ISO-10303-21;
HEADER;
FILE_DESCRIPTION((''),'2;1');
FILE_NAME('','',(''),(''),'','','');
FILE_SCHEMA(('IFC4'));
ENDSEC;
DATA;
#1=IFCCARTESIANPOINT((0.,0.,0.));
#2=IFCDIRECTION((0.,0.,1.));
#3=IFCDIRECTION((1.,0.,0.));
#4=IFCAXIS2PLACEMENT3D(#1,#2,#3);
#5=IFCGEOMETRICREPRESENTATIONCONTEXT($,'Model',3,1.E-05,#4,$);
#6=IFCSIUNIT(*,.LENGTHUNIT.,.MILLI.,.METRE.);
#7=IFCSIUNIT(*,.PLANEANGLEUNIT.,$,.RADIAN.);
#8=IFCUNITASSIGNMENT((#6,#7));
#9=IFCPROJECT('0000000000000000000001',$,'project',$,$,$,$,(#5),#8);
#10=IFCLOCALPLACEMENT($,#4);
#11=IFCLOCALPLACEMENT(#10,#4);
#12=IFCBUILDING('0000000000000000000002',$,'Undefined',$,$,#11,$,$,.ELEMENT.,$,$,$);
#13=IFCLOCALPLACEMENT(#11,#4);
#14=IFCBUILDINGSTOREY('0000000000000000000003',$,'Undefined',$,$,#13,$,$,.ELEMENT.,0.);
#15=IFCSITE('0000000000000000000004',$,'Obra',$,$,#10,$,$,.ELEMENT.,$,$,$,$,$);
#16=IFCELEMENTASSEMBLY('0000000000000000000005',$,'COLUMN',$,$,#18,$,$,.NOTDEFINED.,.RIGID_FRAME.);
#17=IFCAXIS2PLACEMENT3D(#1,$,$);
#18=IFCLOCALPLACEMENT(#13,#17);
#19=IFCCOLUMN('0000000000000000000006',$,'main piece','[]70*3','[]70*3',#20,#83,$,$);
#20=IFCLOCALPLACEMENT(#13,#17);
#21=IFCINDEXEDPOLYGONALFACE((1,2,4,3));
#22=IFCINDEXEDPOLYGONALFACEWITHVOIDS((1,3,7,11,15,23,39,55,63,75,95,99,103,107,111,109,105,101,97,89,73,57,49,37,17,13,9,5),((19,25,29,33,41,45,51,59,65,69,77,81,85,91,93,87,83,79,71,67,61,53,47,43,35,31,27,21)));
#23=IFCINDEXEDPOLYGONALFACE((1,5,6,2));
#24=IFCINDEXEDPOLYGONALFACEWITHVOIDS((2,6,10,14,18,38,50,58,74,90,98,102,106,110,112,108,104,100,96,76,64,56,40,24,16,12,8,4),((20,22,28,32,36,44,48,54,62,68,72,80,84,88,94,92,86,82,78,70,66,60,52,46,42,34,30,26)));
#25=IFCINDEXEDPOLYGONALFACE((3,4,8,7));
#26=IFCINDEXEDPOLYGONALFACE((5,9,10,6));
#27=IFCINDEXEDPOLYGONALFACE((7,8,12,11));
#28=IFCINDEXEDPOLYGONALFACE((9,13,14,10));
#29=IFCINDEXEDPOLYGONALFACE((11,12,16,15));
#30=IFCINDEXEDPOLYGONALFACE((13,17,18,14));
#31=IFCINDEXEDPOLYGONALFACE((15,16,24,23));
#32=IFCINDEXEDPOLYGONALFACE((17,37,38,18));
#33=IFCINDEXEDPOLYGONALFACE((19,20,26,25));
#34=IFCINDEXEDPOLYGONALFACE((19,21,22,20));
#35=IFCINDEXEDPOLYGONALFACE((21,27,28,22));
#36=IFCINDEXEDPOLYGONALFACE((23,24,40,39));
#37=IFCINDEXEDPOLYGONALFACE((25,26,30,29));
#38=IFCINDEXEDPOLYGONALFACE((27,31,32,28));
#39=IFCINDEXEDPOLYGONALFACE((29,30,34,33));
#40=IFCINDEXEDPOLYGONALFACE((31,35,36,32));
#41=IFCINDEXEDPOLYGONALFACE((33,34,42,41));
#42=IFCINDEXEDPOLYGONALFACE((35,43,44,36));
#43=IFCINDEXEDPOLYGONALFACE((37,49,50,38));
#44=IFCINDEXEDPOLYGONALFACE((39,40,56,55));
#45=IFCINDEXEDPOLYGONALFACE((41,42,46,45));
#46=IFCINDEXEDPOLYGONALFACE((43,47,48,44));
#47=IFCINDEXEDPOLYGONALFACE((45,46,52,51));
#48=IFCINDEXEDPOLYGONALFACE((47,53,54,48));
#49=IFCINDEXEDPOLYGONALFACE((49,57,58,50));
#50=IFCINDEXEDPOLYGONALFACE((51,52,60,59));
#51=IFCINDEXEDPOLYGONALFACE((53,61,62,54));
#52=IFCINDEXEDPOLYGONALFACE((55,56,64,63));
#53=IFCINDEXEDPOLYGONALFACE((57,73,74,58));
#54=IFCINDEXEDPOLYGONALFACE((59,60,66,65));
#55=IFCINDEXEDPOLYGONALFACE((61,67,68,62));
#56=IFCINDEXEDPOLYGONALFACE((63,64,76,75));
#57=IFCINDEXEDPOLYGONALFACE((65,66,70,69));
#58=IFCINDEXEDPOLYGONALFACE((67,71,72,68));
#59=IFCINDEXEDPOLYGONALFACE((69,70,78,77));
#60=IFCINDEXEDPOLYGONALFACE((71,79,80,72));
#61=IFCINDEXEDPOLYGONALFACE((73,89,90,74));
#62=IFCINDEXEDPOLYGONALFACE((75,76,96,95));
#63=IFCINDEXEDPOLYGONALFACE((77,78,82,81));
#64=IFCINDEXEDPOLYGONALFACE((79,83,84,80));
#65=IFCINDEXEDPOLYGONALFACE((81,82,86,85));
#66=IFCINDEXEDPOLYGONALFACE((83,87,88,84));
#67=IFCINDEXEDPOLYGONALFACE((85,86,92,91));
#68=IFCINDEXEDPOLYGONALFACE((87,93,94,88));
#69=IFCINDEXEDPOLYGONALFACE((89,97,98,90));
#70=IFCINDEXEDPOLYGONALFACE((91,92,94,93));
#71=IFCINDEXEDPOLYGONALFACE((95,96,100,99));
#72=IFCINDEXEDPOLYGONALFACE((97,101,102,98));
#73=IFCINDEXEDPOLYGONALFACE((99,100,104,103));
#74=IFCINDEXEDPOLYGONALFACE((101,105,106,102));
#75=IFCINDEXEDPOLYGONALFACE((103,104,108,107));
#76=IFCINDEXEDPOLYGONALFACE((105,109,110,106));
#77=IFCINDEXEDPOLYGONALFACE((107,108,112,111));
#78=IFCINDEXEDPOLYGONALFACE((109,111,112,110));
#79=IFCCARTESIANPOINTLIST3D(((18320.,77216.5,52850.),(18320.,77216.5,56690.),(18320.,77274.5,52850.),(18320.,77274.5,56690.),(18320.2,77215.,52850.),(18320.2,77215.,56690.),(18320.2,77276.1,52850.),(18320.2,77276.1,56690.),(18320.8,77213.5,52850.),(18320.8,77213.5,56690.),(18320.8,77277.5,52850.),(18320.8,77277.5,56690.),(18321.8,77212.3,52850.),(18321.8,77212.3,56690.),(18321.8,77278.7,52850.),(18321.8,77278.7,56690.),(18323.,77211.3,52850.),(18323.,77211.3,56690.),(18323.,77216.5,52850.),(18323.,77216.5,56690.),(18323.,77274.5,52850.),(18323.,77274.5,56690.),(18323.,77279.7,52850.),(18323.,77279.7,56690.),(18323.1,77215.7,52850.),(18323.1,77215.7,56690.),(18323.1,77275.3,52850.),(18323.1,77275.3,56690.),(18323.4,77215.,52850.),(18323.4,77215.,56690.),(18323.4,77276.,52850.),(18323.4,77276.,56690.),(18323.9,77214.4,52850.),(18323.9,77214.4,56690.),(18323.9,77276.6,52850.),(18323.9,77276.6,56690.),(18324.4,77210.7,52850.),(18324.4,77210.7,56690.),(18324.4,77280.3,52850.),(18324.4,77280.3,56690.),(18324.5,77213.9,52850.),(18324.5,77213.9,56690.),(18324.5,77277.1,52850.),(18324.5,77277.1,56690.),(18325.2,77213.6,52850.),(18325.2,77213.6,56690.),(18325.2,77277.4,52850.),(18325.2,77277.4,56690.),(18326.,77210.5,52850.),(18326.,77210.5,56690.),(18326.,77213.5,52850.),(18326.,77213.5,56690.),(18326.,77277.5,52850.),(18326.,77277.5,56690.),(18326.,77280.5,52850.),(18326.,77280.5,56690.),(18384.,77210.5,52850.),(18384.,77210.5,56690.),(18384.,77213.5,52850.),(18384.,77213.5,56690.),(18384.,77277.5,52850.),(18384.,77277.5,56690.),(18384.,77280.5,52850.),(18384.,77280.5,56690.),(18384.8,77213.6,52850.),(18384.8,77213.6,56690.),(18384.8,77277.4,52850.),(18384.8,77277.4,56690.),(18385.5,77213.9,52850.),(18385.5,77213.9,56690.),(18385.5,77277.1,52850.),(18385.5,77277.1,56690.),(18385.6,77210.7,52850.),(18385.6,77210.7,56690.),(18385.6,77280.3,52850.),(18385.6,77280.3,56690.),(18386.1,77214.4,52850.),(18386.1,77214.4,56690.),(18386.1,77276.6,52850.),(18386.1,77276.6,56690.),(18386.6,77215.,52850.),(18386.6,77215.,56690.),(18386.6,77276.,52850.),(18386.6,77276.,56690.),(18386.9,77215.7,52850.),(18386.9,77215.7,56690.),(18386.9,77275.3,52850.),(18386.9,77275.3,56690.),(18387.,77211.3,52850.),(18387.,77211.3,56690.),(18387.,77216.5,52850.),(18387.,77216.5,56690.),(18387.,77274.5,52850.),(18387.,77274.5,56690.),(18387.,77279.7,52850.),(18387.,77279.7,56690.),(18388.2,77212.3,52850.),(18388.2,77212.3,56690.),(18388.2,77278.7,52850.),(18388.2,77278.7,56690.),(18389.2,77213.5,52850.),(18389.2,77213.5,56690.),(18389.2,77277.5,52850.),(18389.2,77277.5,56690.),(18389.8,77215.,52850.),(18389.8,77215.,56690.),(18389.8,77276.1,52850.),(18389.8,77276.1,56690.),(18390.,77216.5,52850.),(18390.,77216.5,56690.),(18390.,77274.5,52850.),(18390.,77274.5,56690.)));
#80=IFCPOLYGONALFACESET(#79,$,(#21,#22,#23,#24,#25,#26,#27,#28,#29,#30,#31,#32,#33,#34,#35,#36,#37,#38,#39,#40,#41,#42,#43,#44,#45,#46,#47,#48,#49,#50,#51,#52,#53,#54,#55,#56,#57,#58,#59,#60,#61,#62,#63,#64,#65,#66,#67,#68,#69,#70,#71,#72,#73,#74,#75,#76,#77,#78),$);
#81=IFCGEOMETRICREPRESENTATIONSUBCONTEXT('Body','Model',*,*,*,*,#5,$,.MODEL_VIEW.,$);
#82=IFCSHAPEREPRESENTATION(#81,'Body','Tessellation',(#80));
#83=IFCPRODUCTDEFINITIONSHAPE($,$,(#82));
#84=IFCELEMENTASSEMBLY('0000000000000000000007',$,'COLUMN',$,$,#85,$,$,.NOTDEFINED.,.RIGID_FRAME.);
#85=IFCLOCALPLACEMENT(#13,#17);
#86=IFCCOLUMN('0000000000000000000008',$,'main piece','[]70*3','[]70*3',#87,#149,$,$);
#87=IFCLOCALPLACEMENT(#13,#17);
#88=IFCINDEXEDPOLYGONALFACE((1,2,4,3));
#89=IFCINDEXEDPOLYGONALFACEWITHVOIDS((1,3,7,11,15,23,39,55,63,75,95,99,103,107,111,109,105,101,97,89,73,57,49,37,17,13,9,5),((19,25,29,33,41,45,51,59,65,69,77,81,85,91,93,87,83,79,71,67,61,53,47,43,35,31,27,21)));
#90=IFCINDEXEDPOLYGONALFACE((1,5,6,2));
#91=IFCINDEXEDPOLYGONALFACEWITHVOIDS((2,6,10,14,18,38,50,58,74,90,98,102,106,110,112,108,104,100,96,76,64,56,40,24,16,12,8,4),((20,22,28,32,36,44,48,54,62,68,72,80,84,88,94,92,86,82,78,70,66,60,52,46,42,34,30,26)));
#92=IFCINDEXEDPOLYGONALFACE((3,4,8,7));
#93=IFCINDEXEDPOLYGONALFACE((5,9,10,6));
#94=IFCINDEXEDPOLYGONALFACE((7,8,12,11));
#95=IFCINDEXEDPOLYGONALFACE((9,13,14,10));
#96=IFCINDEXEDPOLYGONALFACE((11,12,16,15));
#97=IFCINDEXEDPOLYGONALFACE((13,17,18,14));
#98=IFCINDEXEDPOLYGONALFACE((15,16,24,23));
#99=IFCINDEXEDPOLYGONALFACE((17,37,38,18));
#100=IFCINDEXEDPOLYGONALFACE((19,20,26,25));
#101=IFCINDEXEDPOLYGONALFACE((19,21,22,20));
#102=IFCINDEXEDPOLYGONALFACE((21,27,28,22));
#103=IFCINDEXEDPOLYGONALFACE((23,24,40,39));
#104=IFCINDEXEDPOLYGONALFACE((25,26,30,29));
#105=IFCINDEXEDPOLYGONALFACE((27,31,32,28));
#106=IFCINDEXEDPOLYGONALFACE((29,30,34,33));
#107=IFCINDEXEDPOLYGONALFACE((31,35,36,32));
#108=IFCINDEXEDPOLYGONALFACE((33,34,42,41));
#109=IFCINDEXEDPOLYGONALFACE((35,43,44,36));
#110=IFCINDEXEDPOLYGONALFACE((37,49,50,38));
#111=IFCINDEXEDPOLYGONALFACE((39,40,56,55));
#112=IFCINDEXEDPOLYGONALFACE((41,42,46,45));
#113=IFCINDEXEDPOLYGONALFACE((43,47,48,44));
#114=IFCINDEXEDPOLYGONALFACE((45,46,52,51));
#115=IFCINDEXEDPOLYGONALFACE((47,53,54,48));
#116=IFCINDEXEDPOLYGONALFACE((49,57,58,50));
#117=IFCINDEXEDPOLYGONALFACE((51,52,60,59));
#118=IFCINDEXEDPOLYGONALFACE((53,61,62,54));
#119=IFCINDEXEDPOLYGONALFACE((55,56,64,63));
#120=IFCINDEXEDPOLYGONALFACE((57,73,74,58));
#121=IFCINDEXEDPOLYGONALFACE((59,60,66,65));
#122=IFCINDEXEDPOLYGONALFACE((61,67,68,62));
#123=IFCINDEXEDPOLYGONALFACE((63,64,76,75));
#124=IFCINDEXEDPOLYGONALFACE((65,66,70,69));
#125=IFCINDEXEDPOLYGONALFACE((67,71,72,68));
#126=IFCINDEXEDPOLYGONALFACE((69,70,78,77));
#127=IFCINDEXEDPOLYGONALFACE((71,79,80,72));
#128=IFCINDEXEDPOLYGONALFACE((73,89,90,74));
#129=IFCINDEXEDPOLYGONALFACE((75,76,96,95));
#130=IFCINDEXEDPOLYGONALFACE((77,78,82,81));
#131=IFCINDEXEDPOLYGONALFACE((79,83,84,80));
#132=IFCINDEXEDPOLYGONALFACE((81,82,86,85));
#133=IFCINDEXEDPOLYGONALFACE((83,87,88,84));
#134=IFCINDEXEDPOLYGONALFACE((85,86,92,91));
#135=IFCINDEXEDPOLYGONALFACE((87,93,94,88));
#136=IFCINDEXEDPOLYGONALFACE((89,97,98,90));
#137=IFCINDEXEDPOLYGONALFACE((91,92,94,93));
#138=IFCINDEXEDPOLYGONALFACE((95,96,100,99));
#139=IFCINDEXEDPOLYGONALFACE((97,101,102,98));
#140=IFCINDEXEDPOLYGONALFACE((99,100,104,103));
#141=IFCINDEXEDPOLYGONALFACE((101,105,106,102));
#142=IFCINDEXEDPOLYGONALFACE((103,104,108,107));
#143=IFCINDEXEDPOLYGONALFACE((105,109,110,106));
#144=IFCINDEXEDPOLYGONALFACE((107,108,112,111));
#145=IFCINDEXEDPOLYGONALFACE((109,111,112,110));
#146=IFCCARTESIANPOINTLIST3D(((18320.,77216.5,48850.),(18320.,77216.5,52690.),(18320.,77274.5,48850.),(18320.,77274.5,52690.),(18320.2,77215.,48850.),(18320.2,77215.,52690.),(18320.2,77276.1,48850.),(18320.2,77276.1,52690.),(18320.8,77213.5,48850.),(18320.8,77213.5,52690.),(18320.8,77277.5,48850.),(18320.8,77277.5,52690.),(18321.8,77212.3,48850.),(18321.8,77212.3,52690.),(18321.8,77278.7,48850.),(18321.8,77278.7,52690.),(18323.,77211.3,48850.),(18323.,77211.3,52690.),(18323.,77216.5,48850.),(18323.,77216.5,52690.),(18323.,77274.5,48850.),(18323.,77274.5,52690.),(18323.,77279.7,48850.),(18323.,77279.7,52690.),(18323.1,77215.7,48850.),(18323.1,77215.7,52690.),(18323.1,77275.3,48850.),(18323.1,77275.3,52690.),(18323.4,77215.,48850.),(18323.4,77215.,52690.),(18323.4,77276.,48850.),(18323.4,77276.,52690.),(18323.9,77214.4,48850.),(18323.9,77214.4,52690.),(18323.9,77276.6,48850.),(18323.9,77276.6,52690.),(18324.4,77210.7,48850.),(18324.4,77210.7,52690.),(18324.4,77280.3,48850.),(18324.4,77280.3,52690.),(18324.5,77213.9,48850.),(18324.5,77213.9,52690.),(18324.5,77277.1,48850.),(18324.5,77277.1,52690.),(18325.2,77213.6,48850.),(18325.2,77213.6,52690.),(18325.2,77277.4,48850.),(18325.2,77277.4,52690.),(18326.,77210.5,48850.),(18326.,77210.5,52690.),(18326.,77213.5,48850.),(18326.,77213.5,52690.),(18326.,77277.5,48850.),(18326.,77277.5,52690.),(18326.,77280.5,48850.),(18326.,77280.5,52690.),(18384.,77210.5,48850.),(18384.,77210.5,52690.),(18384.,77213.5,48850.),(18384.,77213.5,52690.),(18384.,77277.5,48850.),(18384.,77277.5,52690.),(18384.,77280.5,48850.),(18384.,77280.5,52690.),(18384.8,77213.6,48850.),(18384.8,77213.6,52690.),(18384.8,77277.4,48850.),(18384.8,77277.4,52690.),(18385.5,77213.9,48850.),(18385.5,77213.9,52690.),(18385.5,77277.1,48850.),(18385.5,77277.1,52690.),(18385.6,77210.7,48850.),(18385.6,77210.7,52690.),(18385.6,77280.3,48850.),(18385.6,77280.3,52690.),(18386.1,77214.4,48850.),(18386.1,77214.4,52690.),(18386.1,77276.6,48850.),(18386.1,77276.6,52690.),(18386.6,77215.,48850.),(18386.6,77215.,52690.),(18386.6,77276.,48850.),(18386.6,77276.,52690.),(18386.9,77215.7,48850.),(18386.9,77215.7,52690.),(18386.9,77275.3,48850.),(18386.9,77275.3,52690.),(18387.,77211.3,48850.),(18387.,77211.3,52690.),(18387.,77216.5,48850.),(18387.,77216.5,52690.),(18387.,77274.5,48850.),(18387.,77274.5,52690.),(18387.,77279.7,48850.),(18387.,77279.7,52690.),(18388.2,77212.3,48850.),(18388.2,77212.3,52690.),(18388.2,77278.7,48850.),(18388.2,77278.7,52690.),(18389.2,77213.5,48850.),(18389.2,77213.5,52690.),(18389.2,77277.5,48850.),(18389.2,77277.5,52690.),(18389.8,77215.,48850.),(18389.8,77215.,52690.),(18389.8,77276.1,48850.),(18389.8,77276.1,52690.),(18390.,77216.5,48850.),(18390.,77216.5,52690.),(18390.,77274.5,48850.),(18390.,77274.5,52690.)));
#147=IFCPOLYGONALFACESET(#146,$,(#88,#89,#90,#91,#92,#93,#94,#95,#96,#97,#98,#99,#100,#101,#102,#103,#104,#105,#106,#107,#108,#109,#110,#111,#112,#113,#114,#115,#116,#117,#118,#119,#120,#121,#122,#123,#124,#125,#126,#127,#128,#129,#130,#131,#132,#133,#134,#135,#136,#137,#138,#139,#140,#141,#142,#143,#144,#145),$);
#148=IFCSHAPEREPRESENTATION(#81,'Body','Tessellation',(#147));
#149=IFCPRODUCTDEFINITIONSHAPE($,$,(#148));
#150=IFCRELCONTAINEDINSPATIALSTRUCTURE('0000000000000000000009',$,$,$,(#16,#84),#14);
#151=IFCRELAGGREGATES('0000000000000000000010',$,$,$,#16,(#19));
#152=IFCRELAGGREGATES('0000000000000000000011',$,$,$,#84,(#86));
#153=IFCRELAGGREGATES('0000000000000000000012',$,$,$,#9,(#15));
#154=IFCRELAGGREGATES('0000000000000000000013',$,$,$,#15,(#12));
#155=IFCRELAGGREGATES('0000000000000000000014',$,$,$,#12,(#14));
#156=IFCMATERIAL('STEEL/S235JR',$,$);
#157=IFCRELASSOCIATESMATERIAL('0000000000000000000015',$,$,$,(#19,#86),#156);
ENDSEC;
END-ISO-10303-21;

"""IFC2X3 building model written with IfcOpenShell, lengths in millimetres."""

from ifc_helpers import new_model, si_unit, frame, origin_with_axes, origin_2d_with_axis, place, context, subcontext, project, spatial, hollow_rectangle, extrude, material, element, aggregate, save


model = new_model("IFC2X3")

# Units and contexts
model_context = context("Model", 3, precision=1e-05, world=origin_with_axes())
body_context = subcontext(model_context, "Body", "Model", "MODEL_VIEW")
ifc_project = project(units=[si_unit("LENGTHUNIT", "METRE", prefix="MILLI"), si_unit("PLANEANGLEUNIT", "RADIAN")], contexts=[model_context])

# Site, building, storey
site_placement = place(None, origin_with_axes())
site = spatial("IfcSite", under=ifc_project, at=site_placement, Name="Obra", CompositionType="ELEMENT")
building_placement = place(site_placement, origin_with_axes())
building = spatial("IfcBuilding", under=site, at=building_placement, Name="Undefined", CompositionType="ELEMENT")
storey_placement = place(building_placement, origin_with_axes())
storey = spatial("IfcBuildingStorey", under=building, at=storey_placement, Name="Undefined", CompositionType="ELEMENT", Elevation=0.0)

# Element assemblies, columns
assembly_1_placement = place(storey_placement, origin_with_axes())
assembly_1 = element("IfcElementAssembly", 1, at=assembly_1_placement, inside=storey, Name="COLUMN", AssemblyPlace="NOTDEFINED", PredefinedType="RIGID_FRAME")
ifc_material = material(Name="STEEL/S235JR")
column_1_placement = place(assembly_1_placement, frame((18355.0, 77245.5, 52850.0), z_axis=(0.0, 0.0, 1.0), x_axis=(0.0, 1.0, 0.0)))
column_1 = element("IfcColumn", 2, at=column_1_placement, material=ifc_material, Name="main piece", Description="[]70*3", ObjectType="[]70*3", context=body_context, shape_type="SweptSolid", body=[
    extrude(hollow_rectangle(XDim=70.0, YDim=70.0, WallThickness=3.0, InnerFilletRadius=3.0, OuterFilletRadius=6.0, at=origin_2d_with_axis()), frame((0.0, 0.0, 3840.0), z_axis=(0.0, 0.0, -1.0), x_axis=(0.0, 1.0, 0.0)), (0.0, 0.0, 1.0), 3840.0),
])
aggregate(assembly_1, [column_1])
assembly_2_placement = place(storey_placement, origin_with_axes())
assembly_2 = element("IfcElementAssembly", 3, at=assembly_2_placement, inside=storey, Name="COLUMN", AssemblyPlace="NOTDEFINED", PredefinedType="RIGID_FRAME")
column_2_placement = place(assembly_2_placement, frame((18355.0, 77245.5, 48850.0), z_axis=(0.0, 0.0, 1.0), x_axis=(0.0, 1.0, 0.0)))
column_2 = element("IfcColumn", 4, at=column_2_placement, material=ifc_material, Name="main piece", Description="[]70*3", ObjectType="[]70*3", context=body_context, shape_type="SweptSolid", body=[
    extrude(hollow_rectangle(XDim=70.0, YDim=70.0, WallThickness=3.0, InnerFilletRadius=3.0, OuterFilletRadius=6.0, at=origin_2d_with_axis()), frame((0.0, 0.0, 3840.0), z_axis=(0.0, 0.0, -1.0), x_axis=(0.0, 1.0, 0.0)), (0.0, 0.0, 1.0), 3840.0),
])
aggregate(assembly_2, [column_2])

save(model, "model.ifc")
